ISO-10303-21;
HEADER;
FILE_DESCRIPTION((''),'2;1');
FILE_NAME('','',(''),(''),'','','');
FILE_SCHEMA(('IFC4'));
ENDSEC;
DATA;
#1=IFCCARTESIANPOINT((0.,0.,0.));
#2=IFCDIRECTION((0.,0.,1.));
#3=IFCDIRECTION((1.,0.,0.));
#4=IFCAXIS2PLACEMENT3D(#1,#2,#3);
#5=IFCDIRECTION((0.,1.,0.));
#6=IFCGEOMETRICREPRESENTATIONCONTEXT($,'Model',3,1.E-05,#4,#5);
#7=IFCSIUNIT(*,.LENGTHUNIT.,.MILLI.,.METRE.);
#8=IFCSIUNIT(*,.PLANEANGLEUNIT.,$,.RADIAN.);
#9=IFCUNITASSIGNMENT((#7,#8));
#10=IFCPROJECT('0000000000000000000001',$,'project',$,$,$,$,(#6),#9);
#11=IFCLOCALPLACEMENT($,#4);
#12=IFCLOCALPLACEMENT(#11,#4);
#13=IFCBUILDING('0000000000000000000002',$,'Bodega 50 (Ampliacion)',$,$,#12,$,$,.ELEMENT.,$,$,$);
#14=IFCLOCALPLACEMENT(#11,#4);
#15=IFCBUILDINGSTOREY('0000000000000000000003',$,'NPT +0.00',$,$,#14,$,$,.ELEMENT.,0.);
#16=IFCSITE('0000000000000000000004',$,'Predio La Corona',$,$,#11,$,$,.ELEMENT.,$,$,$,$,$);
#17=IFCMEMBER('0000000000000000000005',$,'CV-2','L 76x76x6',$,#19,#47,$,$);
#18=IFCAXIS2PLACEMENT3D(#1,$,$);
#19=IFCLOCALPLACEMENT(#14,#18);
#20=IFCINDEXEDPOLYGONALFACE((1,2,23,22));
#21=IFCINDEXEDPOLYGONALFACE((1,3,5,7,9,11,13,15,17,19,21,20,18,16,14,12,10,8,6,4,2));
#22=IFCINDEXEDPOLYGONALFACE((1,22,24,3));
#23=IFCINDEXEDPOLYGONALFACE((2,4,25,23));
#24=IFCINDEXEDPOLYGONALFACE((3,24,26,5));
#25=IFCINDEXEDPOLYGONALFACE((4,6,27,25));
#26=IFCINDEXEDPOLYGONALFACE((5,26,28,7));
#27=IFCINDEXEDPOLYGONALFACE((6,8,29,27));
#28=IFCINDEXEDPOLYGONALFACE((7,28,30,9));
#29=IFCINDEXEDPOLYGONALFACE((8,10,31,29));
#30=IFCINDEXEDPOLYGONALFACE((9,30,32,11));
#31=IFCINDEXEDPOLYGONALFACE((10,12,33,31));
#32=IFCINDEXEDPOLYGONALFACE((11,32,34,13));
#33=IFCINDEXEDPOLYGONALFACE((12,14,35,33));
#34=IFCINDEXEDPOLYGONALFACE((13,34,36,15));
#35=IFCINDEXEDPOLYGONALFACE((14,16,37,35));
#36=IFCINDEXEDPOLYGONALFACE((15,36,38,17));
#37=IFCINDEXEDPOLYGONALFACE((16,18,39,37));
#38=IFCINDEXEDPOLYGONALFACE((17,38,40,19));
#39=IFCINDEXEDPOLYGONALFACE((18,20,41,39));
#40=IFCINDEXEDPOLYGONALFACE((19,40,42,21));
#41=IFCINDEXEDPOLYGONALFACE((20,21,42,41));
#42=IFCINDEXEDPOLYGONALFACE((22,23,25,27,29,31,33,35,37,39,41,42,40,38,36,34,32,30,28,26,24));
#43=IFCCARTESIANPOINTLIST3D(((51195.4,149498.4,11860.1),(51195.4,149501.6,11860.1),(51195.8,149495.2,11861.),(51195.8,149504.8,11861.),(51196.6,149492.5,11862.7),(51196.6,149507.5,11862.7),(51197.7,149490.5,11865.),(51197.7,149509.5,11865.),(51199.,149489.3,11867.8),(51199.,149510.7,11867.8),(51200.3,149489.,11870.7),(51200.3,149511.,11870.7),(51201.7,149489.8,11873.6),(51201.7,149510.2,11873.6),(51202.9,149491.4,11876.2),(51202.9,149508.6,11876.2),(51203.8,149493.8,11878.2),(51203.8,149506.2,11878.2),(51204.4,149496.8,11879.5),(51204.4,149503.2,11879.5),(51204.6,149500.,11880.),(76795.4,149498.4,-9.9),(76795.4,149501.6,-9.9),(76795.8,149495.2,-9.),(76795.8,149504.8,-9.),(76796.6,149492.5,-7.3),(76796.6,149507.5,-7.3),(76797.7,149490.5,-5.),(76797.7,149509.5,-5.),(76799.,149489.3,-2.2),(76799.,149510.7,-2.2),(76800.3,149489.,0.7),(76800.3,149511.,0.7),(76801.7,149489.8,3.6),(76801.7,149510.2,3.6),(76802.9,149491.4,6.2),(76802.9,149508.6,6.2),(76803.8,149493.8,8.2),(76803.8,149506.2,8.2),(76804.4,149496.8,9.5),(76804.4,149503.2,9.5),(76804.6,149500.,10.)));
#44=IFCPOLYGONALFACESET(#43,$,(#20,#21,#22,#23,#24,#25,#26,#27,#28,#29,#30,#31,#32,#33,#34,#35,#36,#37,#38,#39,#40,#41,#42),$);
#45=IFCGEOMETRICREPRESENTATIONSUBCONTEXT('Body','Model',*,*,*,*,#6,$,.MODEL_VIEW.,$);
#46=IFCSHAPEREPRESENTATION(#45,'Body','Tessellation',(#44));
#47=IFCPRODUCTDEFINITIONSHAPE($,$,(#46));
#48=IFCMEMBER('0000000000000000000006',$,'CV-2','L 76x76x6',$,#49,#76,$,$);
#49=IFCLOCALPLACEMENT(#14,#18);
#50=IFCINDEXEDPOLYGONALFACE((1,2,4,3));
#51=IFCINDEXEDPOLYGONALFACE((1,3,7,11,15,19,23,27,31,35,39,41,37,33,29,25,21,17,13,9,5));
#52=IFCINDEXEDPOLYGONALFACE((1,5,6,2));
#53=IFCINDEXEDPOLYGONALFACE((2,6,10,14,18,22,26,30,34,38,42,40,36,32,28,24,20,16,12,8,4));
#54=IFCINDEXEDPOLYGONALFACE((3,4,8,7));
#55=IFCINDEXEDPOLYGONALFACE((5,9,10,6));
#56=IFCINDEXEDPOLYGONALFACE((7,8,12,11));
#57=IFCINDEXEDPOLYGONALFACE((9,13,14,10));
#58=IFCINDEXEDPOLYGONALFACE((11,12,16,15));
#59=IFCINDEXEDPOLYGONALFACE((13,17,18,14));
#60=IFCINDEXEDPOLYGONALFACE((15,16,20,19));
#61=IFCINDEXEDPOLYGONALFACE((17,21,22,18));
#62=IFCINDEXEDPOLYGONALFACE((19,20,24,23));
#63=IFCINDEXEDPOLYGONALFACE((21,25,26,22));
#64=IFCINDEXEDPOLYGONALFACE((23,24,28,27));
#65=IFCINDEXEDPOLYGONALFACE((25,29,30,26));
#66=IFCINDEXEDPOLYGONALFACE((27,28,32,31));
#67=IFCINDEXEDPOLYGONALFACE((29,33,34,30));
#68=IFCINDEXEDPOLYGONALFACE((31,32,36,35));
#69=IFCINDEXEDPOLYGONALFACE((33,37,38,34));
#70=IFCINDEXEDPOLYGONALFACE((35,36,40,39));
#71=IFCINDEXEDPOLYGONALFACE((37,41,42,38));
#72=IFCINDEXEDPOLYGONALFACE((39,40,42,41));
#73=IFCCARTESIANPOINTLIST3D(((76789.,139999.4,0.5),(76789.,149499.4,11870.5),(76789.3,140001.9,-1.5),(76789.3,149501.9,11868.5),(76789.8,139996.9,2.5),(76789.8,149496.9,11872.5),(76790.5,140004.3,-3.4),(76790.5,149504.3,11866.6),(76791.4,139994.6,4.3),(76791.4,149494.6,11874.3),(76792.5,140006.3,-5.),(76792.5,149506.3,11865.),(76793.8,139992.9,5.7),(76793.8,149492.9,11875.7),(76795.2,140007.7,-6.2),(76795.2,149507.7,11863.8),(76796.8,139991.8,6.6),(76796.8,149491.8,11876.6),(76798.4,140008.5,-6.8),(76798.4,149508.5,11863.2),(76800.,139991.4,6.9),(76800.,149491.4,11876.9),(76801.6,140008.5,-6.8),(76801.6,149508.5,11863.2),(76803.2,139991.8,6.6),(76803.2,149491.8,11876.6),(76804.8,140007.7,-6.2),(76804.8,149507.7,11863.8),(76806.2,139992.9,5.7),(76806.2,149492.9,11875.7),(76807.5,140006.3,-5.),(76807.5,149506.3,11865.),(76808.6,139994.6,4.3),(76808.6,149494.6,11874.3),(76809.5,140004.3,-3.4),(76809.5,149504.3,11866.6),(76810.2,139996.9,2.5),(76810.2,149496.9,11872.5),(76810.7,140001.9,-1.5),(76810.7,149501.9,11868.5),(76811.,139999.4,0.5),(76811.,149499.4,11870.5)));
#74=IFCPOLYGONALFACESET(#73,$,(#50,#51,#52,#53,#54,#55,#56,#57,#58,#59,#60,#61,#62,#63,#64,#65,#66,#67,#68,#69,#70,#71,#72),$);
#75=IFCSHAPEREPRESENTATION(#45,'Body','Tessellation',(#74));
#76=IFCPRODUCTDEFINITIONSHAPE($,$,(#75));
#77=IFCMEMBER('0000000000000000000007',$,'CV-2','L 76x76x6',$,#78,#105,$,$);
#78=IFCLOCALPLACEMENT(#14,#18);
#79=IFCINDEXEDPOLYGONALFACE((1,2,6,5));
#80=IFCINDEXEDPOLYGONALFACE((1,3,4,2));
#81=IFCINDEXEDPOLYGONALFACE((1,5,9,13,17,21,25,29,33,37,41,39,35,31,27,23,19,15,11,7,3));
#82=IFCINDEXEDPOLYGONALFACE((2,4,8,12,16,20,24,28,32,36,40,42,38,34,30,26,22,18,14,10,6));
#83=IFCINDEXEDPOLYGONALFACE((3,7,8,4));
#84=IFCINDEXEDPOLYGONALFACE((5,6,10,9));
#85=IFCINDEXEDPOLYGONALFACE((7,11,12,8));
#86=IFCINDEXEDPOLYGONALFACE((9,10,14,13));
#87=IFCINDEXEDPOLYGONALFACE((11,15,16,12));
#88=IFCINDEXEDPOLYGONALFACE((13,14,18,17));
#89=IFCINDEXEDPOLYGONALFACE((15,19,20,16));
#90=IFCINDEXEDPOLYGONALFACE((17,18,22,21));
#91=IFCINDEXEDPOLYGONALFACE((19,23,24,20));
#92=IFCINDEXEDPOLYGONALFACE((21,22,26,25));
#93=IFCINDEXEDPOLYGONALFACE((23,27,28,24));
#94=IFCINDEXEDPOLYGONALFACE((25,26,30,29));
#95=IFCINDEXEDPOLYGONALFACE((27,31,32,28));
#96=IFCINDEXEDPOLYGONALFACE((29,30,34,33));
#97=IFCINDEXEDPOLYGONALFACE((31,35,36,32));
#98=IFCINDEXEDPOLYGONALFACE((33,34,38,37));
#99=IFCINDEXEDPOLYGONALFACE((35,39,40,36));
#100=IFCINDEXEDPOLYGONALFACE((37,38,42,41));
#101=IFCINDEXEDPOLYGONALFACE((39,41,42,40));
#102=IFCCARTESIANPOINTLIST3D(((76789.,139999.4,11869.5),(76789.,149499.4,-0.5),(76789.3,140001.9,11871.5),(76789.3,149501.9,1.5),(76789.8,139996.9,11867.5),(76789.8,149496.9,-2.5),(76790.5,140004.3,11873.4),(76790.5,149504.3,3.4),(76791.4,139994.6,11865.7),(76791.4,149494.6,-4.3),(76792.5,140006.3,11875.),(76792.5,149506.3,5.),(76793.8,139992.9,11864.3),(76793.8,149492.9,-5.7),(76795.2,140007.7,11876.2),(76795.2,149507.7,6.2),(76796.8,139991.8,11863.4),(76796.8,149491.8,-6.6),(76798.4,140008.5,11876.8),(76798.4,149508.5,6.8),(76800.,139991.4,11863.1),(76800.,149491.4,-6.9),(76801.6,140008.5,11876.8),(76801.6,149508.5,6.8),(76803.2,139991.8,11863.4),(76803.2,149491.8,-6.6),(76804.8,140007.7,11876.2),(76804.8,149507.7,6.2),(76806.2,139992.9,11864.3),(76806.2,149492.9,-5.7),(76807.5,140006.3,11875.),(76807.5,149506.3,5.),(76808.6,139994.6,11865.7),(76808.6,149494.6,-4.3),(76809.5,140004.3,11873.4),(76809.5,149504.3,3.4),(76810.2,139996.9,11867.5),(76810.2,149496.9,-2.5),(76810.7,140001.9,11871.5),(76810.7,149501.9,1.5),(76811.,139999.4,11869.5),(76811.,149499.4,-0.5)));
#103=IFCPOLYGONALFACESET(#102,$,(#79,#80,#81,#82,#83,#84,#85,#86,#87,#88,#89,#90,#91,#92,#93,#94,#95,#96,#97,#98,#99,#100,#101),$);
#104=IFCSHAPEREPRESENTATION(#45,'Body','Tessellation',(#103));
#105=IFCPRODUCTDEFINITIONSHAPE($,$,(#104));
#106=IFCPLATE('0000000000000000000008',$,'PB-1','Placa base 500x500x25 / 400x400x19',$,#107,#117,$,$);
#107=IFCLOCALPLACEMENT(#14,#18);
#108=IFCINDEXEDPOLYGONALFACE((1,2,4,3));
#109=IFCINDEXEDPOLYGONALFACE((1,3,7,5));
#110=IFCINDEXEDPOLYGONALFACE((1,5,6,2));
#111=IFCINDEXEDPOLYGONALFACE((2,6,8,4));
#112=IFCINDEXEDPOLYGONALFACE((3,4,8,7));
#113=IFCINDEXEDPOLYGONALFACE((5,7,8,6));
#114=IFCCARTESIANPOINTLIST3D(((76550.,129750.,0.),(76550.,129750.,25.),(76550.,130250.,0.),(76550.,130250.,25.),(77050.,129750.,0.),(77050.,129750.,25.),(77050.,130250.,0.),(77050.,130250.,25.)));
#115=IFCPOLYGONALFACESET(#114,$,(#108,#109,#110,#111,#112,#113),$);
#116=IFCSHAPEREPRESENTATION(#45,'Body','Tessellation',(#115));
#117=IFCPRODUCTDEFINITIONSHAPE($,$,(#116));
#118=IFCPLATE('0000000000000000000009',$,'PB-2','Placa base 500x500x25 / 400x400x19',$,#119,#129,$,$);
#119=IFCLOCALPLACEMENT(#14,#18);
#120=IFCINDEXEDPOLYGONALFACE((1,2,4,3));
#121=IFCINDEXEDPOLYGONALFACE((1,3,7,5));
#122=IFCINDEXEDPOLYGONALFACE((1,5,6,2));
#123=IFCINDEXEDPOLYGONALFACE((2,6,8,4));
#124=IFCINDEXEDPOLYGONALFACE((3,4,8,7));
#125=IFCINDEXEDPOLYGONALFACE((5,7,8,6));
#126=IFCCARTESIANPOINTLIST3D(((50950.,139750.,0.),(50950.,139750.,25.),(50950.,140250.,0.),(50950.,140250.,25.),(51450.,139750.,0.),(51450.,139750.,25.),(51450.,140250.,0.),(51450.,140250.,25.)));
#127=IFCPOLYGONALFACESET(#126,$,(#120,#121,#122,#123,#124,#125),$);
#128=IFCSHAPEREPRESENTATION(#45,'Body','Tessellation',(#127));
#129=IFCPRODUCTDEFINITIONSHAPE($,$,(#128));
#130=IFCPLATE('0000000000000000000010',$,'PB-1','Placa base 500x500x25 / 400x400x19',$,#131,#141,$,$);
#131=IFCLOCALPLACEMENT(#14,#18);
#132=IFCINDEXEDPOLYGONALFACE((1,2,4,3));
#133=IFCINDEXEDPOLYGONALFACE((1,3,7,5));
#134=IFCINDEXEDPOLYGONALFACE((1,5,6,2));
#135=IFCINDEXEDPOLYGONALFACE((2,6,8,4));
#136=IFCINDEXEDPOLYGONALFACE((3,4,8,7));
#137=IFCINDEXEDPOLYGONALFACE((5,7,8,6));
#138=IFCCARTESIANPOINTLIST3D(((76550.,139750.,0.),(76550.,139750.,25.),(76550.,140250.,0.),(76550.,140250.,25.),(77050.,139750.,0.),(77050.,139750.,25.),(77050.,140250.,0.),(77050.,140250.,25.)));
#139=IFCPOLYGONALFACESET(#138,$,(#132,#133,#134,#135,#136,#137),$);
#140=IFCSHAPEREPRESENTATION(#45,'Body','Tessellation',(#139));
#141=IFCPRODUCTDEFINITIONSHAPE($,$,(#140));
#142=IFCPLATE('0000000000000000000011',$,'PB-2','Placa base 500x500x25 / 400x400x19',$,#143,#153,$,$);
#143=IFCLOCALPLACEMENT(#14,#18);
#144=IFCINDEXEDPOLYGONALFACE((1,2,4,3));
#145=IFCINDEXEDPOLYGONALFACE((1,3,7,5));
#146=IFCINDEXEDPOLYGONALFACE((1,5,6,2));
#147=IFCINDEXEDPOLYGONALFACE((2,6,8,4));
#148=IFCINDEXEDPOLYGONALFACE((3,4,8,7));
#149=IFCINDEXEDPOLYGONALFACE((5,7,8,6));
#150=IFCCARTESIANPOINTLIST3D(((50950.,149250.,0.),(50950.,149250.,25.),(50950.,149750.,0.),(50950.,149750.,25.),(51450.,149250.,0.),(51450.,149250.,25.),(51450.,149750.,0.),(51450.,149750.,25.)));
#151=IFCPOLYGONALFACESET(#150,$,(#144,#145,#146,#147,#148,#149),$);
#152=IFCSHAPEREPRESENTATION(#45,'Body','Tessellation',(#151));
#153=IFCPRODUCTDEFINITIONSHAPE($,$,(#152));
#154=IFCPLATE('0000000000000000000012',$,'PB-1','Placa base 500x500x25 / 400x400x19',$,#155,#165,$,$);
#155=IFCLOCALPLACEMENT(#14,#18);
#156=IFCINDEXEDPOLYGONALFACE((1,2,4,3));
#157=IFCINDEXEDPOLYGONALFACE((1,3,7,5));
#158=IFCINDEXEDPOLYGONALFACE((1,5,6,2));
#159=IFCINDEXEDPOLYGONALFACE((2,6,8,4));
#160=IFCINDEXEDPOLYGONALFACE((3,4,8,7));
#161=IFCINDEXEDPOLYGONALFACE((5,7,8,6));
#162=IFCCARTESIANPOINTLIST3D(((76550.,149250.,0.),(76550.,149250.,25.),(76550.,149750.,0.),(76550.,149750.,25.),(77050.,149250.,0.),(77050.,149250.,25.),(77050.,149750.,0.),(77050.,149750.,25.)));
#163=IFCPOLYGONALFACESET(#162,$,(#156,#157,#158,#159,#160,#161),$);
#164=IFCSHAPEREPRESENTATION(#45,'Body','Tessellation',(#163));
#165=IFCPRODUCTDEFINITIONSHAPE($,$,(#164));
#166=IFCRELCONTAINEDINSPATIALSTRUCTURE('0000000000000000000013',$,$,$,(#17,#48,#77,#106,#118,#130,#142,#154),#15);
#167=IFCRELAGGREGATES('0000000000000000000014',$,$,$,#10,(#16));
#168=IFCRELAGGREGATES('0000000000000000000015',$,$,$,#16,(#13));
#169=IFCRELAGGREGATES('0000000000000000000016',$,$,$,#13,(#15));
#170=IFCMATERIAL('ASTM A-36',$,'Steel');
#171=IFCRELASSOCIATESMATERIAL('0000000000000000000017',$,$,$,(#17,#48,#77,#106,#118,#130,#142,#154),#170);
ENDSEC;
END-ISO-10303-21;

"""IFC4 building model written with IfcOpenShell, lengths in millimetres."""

from ifc_helpers import new_model, si_unit, direction, frame, origin_with_axes, origin_2d, place, context, subcontext, project, spatial, rectangle, circle, extrude, material, element, save


model = new_model("IFC4")

# Units and contexts
model_context = context("Model", 3, precision=1e-05, world=origin_with_axes(), true_north=direction((0.0, 1.0, 0.0)))
body_context = subcontext(model_context, "Body", "Model", "MODEL_VIEW")
ifc_project = project(units=[si_unit("LENGTHUNIT", "METRE", prefix="MILLI"), si_unit("PLANEANGLEUNIT", "RADIAN")], contexts=[model_context])

# Site, building, storey
site_placement = place(None, origin_with_axes())
site = spatial("IfcSite", under=ifc_project, at=site_placement, Name="Predio La Corona", CompositionType="ELEMENT")
building_placement = place(site_placement, origin_with_axes())
building = spatial("IfcBuilding", under=site, at=building_placement, Name="Bodega 50 (Ampliacion)", CompositionType="ELEMENT")
storey_placement = place(site_placement, origin_with_axes())
storey = spatial("IfcBuildingStorey", under=building, at=storey_placement, Name="NPT +0.00", CompositionType="ELEMENT", Elevation=0.0)

# Shared definitions
ifc_material = material(Name="ASTM A-36", Category="Steel")

# Members
for number, where, z_axis, x_axis, name in (
    (1, (76800.0, 149500.0, 0.0), (-0.907222, 0.0, 0.420653), (0.420653, 0.0, 0.907222), "CV-2"),
):
    element("IfcMember", number, at=place(storey_placement, frame(where, z_axis=z_axis, x_axis=x_axis)), inside=storey, material=ifc_material, Name=name, Description="L 76x76x6", context=body_context, shape_type="SweptSolid", body=[
        extrude(circle(Radius=11.0, at=origin_2d()), origin_with_axes(), (0.0, 0.0, 1.0), 28218.0),
    ])
for number, where, z_axis, x_axis, name in (
    (2, (76800.0, 140000.0, 0.0), (0.0, 0.624855, 0.78074), (0.0, -0.78074, 0.624855), "CV-2"),
    (3, (76800.0, 149500.0, 0.0), (0.0, -0.624855, 0.78074), (0.0, -0.78074, -0.624855), "CV-2"),
):
    element("IfcMember", number, at=place(storey_placement, frame(where, z_axis=z_axis, x_axis=x_axis)), inside=storey, material=ifc_material, Name=name, Description="L 76x76x6", context=body_context, shape_type="SweptSolid", body=[
        extrude(circle(Radius=11.0, at=origin_2d()), origin_with_axes(), (0.0, 0.0, 1.0), 15203.5),
    ])

# Plates
for number, where, z_axis, x_axis, name in (
    (4, (76800.0, 130000.0, 0.0), (0.0, 0.0, 1.0), (1.0, 0.0, 0.0), "PB-1"),
    (5, (51200.0, 140000.0, 0.0), (0.0, 0.0, 1.0), (1.0, 0.0, 0.0), "PB-2"),
    (6, (76800.0, 140000.0, 0.0), (0.0, 0.0, 1.0), (1.0, 0.0, 0.0), "PB-1"),
    (7, (51200.0, 149500.0, 0.0), (0.0, 0.0, 1.0), (1.0, 0.0, 0.0), "PB-2"),
    (8, (76800.0, 149500.0, 0.0), (0.0, 0.0, 1.0), (1.0, 0.0, 0.0), "PB-1"),
):
    element("IfcPlate", number, at=place(storey_placement, frame(where, z_axis=z_axis, x_axis=x_axis)), inside=storey, material=ifc_material, Name=name, Description="Placa base 500x500x25 / 400x400x19", context=body_context, shape_type="SweptSolid", body=[
        extrude(rectangle(XDim=500.0, YDim=500.0, at=origin_2d()), origin_with_axes(), (0.0, 0.0, 1.0), 25.0),
    ])

save(model, "model.ifc")
